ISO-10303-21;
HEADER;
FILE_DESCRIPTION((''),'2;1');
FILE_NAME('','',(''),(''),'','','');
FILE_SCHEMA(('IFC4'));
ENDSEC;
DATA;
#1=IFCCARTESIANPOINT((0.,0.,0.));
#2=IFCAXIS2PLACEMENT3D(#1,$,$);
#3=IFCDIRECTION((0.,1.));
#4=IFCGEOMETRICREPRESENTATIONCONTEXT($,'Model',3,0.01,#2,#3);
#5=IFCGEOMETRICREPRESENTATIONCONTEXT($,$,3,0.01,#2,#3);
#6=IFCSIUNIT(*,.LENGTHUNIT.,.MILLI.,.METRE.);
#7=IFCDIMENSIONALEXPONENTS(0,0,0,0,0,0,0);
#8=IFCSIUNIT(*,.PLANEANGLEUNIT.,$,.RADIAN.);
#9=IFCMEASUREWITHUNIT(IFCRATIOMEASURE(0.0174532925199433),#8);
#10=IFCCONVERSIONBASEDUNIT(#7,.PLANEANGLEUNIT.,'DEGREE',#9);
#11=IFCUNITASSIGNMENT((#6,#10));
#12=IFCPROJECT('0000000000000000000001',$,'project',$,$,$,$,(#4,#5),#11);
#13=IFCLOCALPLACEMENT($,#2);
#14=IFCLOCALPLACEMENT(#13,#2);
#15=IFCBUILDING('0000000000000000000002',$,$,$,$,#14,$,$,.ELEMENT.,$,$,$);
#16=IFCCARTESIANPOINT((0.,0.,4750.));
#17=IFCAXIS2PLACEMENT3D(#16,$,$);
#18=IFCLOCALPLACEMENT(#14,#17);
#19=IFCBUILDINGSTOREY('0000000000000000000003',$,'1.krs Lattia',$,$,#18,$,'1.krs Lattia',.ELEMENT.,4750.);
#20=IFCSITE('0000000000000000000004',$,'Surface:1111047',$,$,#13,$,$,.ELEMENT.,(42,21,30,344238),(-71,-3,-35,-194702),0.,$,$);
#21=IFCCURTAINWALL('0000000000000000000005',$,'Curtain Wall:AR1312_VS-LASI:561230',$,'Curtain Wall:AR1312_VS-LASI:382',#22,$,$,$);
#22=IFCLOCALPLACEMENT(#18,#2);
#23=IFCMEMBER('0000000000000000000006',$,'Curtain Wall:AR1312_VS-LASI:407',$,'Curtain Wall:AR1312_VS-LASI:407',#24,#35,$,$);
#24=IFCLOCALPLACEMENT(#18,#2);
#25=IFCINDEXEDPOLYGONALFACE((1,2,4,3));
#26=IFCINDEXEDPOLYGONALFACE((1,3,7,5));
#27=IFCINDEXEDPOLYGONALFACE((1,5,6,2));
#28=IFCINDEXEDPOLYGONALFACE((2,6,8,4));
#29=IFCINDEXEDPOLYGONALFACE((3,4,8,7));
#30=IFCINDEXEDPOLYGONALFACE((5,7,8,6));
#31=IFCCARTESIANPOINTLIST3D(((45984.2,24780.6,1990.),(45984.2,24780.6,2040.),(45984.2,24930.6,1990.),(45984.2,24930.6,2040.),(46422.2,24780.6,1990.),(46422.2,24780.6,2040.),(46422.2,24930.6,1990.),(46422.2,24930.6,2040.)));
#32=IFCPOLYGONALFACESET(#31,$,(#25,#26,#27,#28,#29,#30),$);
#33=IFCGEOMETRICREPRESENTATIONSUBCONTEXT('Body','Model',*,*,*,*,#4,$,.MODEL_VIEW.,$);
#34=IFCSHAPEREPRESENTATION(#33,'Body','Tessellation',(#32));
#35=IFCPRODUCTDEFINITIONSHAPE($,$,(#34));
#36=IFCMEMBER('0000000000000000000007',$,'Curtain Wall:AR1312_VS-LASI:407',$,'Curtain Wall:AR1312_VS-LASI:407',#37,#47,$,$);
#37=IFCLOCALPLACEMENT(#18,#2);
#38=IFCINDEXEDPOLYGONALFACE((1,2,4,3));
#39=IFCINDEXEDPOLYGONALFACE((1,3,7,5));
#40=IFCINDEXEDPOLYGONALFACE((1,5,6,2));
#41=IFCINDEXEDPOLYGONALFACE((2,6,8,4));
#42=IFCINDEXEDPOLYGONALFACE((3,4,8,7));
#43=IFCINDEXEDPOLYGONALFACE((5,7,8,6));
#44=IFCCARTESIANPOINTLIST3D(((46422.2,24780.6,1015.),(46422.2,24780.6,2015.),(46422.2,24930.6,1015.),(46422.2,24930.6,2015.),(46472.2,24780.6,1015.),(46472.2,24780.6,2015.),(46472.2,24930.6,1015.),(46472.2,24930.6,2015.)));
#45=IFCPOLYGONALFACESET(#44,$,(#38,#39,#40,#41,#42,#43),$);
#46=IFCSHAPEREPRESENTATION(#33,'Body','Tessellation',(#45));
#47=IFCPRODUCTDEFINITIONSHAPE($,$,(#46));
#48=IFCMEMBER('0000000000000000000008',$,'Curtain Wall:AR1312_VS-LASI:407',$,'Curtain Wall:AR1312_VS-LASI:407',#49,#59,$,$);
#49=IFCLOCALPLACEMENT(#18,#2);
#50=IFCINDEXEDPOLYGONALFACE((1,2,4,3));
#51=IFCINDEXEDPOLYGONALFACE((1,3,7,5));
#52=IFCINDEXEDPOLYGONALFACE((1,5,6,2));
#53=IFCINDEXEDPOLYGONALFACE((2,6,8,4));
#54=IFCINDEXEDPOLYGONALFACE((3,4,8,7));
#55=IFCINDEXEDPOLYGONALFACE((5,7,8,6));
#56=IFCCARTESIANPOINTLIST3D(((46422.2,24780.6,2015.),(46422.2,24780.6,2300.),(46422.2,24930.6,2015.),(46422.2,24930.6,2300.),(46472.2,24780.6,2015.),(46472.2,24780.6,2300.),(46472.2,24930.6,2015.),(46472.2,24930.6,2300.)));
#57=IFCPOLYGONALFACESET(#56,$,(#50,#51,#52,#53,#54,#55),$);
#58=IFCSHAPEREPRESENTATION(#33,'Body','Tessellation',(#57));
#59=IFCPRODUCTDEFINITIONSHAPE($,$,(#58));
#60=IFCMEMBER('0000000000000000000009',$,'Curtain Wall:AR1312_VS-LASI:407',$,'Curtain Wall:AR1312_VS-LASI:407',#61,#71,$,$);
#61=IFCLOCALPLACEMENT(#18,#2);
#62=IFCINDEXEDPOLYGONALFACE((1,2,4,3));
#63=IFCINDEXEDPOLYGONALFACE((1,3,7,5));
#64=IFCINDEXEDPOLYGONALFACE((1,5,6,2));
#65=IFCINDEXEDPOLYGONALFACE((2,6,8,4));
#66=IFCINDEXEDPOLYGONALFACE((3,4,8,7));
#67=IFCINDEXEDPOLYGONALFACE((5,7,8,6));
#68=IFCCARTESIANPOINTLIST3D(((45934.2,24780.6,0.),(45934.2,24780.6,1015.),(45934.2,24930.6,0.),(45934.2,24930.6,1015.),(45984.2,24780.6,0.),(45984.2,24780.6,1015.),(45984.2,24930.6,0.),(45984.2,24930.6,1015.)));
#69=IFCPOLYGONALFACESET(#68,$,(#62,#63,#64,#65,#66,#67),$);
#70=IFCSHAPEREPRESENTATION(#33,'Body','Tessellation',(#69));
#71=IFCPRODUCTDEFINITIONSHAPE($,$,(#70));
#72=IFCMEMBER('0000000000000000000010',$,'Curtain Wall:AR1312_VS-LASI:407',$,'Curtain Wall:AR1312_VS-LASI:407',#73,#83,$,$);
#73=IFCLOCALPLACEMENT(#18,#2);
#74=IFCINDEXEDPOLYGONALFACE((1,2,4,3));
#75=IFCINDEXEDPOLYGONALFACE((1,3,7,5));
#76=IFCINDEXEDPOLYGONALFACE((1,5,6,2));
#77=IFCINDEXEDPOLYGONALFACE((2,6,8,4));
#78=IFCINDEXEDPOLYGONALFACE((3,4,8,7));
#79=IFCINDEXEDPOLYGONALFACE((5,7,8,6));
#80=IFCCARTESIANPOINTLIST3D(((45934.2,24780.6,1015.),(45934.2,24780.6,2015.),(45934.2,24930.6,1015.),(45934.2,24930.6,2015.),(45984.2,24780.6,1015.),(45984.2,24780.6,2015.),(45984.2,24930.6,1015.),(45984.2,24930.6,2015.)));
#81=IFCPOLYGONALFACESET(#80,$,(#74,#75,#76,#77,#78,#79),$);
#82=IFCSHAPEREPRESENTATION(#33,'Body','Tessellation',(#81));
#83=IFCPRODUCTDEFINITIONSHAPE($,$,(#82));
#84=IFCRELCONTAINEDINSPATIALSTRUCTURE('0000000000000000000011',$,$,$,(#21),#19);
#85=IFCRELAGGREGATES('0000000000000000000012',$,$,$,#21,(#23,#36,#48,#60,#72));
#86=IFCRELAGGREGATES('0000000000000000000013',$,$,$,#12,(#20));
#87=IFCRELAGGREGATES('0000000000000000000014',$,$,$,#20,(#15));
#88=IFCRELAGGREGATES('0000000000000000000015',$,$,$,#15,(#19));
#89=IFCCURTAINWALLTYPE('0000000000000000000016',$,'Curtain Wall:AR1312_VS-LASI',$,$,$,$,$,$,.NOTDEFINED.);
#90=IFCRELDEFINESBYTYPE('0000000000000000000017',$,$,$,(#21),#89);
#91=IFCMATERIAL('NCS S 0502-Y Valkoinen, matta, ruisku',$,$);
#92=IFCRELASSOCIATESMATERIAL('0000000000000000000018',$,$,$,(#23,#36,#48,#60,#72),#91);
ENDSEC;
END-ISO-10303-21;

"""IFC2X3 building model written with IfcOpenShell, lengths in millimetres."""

from ifc_helpers import new_model, entity, si_unit, converted_unit, direction, frame, frame_2d, origin, place, context, subcontext, project, spatial, rectangle, extrude, material, type_object, element, aggregate, save


model = new_model("IFC2X3")

# Units and contexts
model_context = context("Model", 3, precision=0.01, world=origin(), true_north=direction((0.0, 1.0)))
context_of_model = context(None, 3, precision=0.01, world=origin(), true_north=direction((0.0, 1.0)))
body_context = subcontext(model_context, "Body", "Model", "MODEL_VIEW")
ifc_project = project(units=[si_unit("LENGTHUNIT", "METRE", prefix="MILLI"), converted_unit("PLANEANGLEUNIT", "DEGREE", entity("IfcRatioMeasure", 0.0174532925199433), si_unit("PLANEANGLEUNIT", "RADIAN"), dimensions=[0, 0, 0, 0, 0, 0, 0])], contexts=[model_context, context_of_model])

# Site, building, storey
site_placement = place(None, origin())
site = spatial("IfcSite", under=ifc_project, at=site_placement, Name="Surface:1111047", CompositionType="ELEMENT", RefLatitude=(42, 21, 30, 344238), RefLongitude=(-71, -3, -35, -194702), RefElevation=0.0)
building_placement = place(site_placement, origin())
building = spatial("IfcBuilding", under=site, at=building_placement, CompositionType="ELEMENT")
storey_placement = place(building_placement, frame((0.0, 0.0, 4750.0)))
storey = spatial("IfcBuildingStorey", under=building, at=storey_placement, Name="1.krs Lattia", LongName="1.krs Lattia", CompositionType="ELEMENT", Elevation=4750.0)

# Curtain wall, members
curtain_wall_type = type_object("IfcCurtainWallType", Name="Curtain Wall:AR1312_VS-LASI", PredefinedType="NOTDEFINED")
ifc_material = material(Name="NCS S 0502-Y Valkoinen, matta, ruisku")
curtain_wall_1_placement = place(storey_placement, frame((0.0, 0.0, -4750.0)))
curtain_wall_1 = element("IfcCurtainWall", 1, at=curtain_wall_1_placement, inside=storey, type_object=curtain_wall_type, Name="Curtain Wall:AR1312_VS-LASI:561230", ObjectType="Curtain Wall:AR1312_VS-LASI:382")
member_1_placement = place(curtain_wall_1_placement, frame((0.0, 0.0, 4750.0)))
member_1 = element("IfcMember", 2, at=member_1_placement, material=ifc_material, Name="Curtain Wall:AR1312_VS-LASI:407", ObjectType="Curtain Wall:AR1312_VS-LASI:407", context=body_context, shape_type="SweptSolid", body=[
    extrude(rectangle(XDim=50.0, YDim=150.0, at=frame_2d((0.0, 0.0), x_axis=(1.0, 0.0))), frame((46422.2, 24855.6, 2015.0), z_axis=(-1.0, 0.0, 0.0), x_axis=(0.0, 0.0, -1.0)), (0.0, 0.0, 1.0), 438.0),
])
member_2_placement = place(curtain_wall_1_placement, frame((0.0, 0.0, 4750.0)))
member_2 = element("IfcMember", 3, at=member_2_placement, material=ifc_material, Name="Curtain Wall:AR1312_VS-LASI:407", ObjectType="Curtain Wall:AR1312_VS-LASI:407", context=body_context, shape_type="SweptSolid", body=[
    extrude(rectangle(XDim=50.0, YDim=150.0, at=frame_2d((0.0, 0.0), x_axis=(1.0, 0.0))), frame((46447.2, 24855.6, 1015.0), z_axis=(0.0, 0.0, 1.0), x_axis=(-1.0, 0.0, 0.0)), (0.0, 0.0, 1.0), 1000.0),
])
member_3_placement = place(curtain_wall_1_placement, frame((0.0, 0.0, 4750.0)))
member_3 = element("IfcMember", 4, at=member_3_placement, material=ifc_material, Name="Curtain Wall:AR1312_VS-LASI:407", ObjectType="Curtain Wall:AR1312_VS-LASI:407", context=body_context, shape_type="SweptSolid", body=[
    extrude(rectangle(XDim=50.0, YDim=150.0, at=frame_2d((0.0, 0.0), x_axis=(1.0, 0.0))), frame((46447.2, 24855.6, 2015.0), z_axis=(0.0, 0.0, 1.0), x_axis=(-1.0, 0.0, 0.0)), (0.0, 0.0, 1.0), 285.0),
])
member_4_placement = place(curtain_wall_1_placement, frame((0.0, 0.0, 4750.0)))
member_4 = element("IfcMember", 5, at=member_4_placement, material=ifc_material, Name="Curtain Wall:AR1312_VS-LASI:407", ObjectType="Curtain Wall:AR1312_VS-LASI:407", context=body_context, shape_type="SweptSolid", body=[
    extrude(rectangle(XDim=50.0, YDim=150.0, at=frame_2d((0.0, 0.0), x_axis=(1.0, 0.0))), frame((45959.2, 24855.6, 1015.0), z_axis=(0.0, 0.0, -1.0), x_axis=(-1.0, 0.0, 0.0)), (0.0, 0.0, 1.0), 1015.0),
])
member_5_placement = place(curtain_wall_1_placement, frame((0.0, 0.0, 4750.0)))
member_5 = element("IfcMember", 6, at=member_5_placement, material=ifc_material, Name="Curtain Wall:AR1312_VS-LASI:407", ObjectType="Curtain Wall:AR1312_VS-LASI:407", context=body_context, shape_type="SweptSolid", body=[
    extrude(rectangle(XDim=50.0, YDim=150.0, at=frame_2d((0.0, 0.0), x_axis=(1.0, 0.0))), frame((45959.2, 24855.6, 2015.0), z_axis=(0.0, 0.0, -1.0), x_axis=(-1.0, 0.0, 0.0)), (0.0, 0.0, 1.0), 1000.0),
])
aggregate(curtain_wall_1, [member_1, member_2, member_3, member_4, member_5])

save(model, "model.ifc")
